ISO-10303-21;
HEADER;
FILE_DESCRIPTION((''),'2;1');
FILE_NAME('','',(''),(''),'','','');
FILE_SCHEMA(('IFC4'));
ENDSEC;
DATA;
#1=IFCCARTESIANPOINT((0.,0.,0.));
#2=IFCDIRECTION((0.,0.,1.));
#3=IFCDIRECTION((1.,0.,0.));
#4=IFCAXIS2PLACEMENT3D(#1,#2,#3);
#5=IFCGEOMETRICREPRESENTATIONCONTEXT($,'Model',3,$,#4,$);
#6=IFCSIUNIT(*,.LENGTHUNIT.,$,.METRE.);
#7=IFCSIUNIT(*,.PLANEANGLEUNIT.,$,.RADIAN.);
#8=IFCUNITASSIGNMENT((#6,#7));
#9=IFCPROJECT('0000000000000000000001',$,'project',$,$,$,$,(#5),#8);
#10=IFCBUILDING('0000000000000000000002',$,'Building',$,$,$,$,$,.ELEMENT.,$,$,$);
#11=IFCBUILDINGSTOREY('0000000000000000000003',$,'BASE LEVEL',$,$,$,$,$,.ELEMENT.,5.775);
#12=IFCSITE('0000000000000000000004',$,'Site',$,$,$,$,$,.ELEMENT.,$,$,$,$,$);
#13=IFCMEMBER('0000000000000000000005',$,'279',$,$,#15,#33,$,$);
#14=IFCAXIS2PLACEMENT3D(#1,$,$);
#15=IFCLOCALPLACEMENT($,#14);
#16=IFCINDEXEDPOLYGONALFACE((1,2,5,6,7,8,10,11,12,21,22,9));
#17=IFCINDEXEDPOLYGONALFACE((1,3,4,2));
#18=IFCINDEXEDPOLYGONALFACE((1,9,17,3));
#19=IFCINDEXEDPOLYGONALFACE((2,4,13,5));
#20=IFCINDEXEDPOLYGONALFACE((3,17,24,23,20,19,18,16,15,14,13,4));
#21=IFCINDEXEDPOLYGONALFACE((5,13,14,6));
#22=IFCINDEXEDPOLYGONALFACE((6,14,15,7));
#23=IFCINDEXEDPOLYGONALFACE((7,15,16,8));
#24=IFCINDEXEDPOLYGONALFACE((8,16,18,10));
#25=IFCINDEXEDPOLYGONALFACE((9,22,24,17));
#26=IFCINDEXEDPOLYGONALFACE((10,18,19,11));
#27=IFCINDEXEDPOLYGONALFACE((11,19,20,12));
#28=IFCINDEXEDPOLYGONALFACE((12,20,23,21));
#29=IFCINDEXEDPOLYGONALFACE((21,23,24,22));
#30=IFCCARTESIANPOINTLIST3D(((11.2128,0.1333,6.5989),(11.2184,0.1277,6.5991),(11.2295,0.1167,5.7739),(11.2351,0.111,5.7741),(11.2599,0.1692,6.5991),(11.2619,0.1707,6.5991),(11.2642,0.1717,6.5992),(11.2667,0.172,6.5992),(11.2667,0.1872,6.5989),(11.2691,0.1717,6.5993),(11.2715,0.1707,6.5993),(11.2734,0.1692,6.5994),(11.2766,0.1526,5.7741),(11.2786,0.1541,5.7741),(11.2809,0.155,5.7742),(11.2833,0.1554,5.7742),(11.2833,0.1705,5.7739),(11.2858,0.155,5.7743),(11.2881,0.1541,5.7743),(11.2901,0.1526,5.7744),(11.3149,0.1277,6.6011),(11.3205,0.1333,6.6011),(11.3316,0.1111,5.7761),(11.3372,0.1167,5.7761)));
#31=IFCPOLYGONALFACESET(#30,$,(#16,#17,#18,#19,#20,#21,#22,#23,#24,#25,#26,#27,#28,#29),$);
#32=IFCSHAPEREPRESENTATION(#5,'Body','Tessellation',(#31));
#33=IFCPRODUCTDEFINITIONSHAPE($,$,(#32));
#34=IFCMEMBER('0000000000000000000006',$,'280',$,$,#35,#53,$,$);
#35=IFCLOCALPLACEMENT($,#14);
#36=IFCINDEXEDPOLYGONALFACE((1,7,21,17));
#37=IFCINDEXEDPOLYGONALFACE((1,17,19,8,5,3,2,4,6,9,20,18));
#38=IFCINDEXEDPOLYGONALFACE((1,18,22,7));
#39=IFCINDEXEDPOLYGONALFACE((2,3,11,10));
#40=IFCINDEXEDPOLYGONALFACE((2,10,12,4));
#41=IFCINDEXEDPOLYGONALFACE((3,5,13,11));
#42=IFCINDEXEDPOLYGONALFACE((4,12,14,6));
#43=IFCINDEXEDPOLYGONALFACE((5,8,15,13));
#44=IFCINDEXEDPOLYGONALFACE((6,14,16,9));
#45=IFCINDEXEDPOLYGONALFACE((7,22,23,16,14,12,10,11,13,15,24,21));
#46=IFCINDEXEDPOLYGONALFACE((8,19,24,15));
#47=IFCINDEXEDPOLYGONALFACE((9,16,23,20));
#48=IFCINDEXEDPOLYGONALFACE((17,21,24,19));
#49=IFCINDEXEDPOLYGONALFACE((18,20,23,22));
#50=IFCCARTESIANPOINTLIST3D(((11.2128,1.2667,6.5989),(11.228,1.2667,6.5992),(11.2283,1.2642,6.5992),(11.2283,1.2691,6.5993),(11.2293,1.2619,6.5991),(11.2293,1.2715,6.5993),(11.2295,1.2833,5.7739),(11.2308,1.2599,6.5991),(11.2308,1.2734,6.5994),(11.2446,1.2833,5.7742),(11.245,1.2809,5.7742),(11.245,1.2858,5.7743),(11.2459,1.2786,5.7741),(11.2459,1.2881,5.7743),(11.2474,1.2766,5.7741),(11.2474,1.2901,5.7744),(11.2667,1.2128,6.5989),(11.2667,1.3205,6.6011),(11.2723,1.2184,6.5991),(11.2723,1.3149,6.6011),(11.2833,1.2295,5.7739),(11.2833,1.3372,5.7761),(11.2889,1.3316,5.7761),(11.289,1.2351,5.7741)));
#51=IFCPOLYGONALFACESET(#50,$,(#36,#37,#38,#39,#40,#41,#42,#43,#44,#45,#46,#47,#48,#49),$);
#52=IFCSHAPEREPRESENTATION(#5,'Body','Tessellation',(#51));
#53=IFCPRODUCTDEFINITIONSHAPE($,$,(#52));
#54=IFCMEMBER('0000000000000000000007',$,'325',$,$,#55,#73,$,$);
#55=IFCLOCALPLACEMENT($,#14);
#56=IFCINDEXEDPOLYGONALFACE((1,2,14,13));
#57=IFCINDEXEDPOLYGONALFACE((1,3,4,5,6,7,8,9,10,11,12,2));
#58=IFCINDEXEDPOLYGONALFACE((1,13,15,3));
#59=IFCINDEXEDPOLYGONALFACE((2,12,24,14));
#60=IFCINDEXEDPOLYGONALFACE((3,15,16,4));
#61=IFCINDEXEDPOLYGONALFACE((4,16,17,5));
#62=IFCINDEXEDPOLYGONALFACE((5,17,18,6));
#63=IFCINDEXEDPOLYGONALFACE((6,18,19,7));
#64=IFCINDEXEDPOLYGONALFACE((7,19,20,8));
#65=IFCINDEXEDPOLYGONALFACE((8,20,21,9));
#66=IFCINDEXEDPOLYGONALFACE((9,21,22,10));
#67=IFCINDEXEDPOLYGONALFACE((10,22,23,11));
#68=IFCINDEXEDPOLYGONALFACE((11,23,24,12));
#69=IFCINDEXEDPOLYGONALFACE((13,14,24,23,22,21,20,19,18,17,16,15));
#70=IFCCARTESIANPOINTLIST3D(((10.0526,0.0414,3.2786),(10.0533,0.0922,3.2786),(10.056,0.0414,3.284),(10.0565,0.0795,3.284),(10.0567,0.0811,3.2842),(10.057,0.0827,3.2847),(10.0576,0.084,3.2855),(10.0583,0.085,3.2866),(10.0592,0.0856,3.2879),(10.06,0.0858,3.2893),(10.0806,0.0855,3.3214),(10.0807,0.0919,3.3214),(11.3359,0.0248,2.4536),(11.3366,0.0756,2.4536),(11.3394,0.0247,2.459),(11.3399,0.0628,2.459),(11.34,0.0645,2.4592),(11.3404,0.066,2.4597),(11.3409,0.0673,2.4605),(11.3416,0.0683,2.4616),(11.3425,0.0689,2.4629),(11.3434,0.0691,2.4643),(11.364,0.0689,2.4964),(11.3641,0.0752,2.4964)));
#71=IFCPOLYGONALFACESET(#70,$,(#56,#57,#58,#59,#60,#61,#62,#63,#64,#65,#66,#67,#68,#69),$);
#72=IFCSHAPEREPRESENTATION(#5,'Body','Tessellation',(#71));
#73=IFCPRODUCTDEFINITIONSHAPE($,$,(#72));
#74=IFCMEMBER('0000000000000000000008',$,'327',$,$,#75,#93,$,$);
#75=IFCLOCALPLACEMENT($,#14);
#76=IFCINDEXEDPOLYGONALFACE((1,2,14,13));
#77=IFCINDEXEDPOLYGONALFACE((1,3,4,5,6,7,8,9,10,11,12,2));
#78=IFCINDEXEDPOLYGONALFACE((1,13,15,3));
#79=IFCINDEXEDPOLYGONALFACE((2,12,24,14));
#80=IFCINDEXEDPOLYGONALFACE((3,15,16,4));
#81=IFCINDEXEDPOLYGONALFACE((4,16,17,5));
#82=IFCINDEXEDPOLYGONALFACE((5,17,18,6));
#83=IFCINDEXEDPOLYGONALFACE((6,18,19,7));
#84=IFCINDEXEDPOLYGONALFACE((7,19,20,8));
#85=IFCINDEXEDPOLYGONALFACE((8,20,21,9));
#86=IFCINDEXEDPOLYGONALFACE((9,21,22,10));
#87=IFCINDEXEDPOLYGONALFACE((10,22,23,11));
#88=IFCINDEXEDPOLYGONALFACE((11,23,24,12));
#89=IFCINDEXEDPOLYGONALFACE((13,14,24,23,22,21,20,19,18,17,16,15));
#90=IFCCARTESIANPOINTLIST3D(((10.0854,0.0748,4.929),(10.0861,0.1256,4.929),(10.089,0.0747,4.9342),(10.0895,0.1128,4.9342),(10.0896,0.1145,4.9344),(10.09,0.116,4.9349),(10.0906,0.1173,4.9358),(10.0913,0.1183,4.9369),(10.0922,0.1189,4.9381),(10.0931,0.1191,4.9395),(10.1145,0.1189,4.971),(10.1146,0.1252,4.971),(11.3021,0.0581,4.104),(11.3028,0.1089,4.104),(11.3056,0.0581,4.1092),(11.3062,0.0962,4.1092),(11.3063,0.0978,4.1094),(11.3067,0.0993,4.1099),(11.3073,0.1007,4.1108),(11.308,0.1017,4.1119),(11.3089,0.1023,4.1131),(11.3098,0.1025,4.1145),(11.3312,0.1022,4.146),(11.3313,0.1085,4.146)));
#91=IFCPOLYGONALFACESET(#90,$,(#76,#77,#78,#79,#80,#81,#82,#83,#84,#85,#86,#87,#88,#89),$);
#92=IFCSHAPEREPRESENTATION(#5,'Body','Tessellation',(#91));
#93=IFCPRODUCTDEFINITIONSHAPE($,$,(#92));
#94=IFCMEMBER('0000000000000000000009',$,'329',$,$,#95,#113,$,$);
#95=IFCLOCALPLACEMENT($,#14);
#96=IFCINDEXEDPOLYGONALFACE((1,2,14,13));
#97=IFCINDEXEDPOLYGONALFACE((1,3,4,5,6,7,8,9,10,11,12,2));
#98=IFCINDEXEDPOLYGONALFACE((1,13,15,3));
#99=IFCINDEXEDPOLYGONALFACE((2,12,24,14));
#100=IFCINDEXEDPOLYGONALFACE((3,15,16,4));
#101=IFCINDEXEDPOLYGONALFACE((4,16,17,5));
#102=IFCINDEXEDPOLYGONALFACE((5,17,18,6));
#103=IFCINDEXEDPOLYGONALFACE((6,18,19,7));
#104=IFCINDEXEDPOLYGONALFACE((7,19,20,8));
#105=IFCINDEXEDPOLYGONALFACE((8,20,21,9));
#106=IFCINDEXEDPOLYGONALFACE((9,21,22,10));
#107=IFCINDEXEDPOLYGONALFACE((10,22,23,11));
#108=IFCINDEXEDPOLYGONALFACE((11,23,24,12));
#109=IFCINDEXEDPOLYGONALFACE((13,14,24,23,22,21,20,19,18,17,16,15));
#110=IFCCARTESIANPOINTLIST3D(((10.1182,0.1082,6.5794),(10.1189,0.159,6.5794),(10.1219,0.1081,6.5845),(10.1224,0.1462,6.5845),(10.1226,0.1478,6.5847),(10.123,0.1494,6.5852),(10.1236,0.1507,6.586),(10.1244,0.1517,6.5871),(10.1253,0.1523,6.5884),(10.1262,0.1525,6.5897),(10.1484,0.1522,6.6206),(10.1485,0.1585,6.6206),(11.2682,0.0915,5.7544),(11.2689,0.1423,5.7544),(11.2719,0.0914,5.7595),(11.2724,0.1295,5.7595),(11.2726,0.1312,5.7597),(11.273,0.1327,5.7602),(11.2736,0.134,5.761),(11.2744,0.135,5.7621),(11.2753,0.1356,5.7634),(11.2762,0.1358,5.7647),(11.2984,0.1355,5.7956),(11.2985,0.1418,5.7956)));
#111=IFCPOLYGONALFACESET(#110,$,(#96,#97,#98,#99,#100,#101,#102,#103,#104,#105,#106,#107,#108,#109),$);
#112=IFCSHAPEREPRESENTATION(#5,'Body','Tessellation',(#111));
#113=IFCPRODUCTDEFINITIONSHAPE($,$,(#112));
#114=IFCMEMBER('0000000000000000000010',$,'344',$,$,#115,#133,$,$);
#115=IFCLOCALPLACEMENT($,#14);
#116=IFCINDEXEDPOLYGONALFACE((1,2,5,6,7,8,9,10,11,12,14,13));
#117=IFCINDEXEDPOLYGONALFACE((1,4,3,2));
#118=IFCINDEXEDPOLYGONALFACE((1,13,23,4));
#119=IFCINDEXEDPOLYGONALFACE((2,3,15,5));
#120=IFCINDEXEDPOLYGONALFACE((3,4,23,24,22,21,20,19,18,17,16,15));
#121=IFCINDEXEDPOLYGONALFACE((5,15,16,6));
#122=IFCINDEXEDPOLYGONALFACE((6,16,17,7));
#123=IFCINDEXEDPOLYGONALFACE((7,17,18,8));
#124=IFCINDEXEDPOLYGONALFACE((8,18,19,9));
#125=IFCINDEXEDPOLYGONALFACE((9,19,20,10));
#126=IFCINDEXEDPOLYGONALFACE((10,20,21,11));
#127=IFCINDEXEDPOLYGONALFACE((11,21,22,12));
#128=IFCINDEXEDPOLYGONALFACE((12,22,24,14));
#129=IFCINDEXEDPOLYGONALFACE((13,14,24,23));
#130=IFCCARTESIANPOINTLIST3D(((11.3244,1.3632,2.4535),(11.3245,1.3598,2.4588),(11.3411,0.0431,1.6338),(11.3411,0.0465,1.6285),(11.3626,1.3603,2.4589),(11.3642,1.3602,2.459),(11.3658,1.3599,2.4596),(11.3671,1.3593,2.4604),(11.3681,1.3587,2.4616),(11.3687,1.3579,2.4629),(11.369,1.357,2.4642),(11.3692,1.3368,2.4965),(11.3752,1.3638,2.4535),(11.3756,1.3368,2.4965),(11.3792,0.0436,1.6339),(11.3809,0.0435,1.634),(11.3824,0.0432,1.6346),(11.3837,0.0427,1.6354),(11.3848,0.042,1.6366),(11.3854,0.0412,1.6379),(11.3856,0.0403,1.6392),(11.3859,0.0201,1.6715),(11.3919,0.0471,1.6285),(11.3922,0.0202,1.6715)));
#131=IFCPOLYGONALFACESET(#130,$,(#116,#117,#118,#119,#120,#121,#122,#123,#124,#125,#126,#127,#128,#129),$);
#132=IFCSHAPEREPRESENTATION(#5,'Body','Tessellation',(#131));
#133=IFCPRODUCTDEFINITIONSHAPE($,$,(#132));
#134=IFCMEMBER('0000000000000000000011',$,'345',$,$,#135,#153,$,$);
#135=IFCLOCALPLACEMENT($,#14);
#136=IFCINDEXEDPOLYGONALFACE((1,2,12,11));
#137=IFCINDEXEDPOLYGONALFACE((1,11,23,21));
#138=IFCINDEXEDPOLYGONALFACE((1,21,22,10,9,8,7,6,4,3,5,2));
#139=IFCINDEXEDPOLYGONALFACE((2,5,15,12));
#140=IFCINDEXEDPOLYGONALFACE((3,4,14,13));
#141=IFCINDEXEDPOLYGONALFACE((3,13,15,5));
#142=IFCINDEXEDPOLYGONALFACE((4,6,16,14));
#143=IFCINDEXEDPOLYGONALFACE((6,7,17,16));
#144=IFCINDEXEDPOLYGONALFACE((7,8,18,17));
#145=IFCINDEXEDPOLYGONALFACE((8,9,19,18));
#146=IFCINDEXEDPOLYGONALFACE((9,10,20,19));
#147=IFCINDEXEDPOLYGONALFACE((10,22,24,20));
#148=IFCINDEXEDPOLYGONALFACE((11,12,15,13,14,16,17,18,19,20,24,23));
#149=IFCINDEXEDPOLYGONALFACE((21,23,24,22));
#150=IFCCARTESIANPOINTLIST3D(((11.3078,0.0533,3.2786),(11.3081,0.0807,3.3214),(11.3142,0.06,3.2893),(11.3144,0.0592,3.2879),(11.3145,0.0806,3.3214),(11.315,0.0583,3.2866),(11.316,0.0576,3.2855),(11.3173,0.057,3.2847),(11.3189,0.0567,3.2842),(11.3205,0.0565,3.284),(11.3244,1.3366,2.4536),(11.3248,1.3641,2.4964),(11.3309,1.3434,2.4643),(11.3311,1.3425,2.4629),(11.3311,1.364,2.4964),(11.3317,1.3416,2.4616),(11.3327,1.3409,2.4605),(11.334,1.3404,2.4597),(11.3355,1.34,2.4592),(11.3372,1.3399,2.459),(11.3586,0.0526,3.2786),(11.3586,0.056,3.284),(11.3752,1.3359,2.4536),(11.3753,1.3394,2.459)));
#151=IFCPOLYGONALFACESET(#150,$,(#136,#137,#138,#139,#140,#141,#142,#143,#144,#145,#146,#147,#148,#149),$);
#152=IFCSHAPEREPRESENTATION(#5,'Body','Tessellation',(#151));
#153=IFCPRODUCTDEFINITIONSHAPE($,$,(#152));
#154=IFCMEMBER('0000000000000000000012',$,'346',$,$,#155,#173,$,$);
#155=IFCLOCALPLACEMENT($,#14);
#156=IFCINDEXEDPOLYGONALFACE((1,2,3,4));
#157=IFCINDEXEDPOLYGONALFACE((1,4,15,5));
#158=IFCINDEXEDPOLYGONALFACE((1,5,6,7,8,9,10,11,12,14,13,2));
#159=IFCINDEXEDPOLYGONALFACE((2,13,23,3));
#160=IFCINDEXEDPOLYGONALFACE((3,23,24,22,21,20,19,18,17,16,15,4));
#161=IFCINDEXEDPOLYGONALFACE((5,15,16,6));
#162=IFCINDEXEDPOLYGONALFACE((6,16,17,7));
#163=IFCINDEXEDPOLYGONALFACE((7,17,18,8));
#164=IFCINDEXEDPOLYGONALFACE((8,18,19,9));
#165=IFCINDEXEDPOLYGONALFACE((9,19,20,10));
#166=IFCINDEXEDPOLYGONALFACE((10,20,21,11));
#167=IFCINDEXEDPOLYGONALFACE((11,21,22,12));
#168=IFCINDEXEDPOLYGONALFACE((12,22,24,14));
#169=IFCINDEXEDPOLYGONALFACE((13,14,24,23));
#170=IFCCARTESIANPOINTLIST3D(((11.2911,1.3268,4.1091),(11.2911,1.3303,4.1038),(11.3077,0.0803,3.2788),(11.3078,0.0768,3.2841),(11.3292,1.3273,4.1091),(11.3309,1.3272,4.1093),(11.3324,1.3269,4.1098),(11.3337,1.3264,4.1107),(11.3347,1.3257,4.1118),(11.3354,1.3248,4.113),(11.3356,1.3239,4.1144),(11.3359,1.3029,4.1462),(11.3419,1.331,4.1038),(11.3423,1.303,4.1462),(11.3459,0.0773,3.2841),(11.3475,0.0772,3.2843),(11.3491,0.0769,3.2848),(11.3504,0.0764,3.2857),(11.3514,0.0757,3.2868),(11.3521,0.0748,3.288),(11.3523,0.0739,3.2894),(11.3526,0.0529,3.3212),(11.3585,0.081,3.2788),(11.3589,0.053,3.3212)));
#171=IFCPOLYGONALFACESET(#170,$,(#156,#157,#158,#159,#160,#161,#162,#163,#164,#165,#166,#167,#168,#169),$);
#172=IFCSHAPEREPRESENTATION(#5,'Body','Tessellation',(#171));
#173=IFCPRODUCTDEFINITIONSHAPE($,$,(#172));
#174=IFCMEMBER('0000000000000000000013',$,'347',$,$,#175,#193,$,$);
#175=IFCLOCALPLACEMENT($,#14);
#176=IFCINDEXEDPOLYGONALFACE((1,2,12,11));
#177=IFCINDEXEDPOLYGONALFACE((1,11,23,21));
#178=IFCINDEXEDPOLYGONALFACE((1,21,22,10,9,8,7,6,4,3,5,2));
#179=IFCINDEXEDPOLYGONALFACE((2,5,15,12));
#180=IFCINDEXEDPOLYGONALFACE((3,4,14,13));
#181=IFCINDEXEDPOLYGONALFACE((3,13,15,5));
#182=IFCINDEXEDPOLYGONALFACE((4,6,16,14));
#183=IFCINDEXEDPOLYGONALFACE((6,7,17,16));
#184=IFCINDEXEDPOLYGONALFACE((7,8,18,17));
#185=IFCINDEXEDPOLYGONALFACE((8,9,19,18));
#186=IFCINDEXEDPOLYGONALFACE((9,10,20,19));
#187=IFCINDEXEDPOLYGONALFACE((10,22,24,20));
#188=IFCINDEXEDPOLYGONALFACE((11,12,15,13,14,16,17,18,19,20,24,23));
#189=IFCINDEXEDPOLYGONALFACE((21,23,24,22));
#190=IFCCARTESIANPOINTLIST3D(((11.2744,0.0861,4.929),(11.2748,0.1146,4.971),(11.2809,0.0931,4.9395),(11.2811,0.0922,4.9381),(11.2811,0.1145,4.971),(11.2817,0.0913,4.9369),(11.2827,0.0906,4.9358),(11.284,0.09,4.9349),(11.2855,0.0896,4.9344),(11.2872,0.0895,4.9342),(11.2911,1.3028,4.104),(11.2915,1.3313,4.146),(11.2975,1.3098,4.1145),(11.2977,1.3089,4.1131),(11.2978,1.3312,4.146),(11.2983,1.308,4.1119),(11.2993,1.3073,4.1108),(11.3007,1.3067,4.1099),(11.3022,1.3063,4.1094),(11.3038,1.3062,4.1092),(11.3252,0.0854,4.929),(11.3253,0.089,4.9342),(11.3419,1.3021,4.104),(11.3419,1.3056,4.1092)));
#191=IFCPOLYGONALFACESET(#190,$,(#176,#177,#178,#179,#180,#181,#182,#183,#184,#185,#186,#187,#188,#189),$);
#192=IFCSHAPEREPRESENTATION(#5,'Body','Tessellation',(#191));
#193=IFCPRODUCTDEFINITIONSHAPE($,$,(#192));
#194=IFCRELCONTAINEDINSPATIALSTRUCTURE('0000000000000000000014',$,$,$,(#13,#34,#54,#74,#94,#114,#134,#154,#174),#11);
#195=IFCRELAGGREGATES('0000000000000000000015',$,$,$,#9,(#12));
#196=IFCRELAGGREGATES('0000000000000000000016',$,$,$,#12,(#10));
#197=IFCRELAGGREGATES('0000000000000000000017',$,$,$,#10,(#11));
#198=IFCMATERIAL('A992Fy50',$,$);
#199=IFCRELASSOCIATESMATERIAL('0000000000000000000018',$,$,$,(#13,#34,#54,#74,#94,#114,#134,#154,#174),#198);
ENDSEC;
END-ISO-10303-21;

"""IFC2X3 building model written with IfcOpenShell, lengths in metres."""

from ifc_helpers import new_model, si_unit, frame, origin_with_axes, origin_2d_with_axis, place, context, project, spatial, l_section, extrude, material, element, save


model = new_model("IFC2X3")

# Units and contexts
model_context = context("Model", 3, world=origin_with_axes())
ifc_project = project(units=[si_unit("LENGTHUNIT", "METRE"), si_unit("PLANEANGLEUNIT", "RADIAN")], contexts=[model_context])

# Site, building, storey
site = spatial("IfcSite", under=ifc_project, Name="Site", CompositionType="ELEMENT")
building = spatial("IfcBuilding", under=site, Name="Building", CompositionType="ELEMENT")
storey = spatial("IfcBuildingStorey", under=building, Name="BASE LEVEL", CompositionType="ELEMENT", Elevation=5.775)

# Members
ifc_material = material(Name="A992Fy50")
for number, where, z_axis, x_axis, name in (
    (1, (11.2833, 0.1167, 5.775), (-0.020194, 0.020194, 0.999592), (-0.707107, -0.707107, 0.0), "279"),
    (2, (11.2833, 1.2833, 5.775), (-0.020194, -0.020194, 0.999592), (0.707107, -0.707107, 0.0), "280"),
):
    element("IfcMember", number, at=place(None, frame(where, z_axis=z_axis, x_axis=x_axis)), inside=storey, material=ifc_material, Name=name, context=model_context, shape_type="SweptSolid", body=[
        extrude(l_section(Depth=0.0762, Width=0.0762, Thickness=0.0079, FilletRadius=0.0096, at=origin_2d_with_axis()), origin_with_axes(), (0.0, 0.0, 1.0), 0.8253),
    ])
member_1_placement = place(None, frame((11.35, 0.05, 2.475), z_axis=(-0.841128, 0.010924, 0.540725), x_axis=(-0.012345, -0.999924, 0.0)))
element("IfcMember", 3, at=member_1_placement, inside=storey, material=ifc_material, Name="325", context=model_context, shape_type="SweptSolid", body=[
    extrude(l_section(Depth=0.0508, Width=0.0508, Thickness=0.0063, FilletRadius=0.0063, at=origin_2d_with_axis()), origin_with_axes(), (0.0, 0.0, 1.0), 1.5257),
])
member_2_placement = place(None, frame((11.3167, 0.0833, 4.125), z_axis=(-0.827611, 0.011337, 0.561188), x_axis=(-0.013697, -0.999906, 0.0)))
element("IfcMember", 4, at=member_2_placement, inside=storey, material=ifc_material, Name="327", context=model_context, shape_type="SweptSolid", body=[
    extrude(l_section(Depth=0.0508, Width=0.0508, Thickness=0.0063, FilletRadius=0.0063, at=origin_2d_with_axis()), origin_with_axes(), (0.0, 0.0, 1.0), 1.4701),
])
member_3_placement = place(None, frame((11.2833, 0.1167, 5.775), z_axis=(-0.812482, 0.011775, 0.582867), x_axis=(-0.015383, -0.999882, 0.0)))
element("IfcMember", 5, at=member_3_placement, inside=storey, material=ifc_material, Name="329", context=model_context, shape_type="SweptSolid", body=[
    extrude(l_section(Depth=0.0508, Width=0.0508, Thickness=0.0063, FilletRadius=0.0063, at=origin_2d_with_axis()), origin_with_axes(), (0.0, 0.0, 1.0), 1.4154),
])
member_4_placement = place(None, frame((11.3667, 0.0333, 1.65), z_axis=(-0.010726, 0.847346, 0.530932), x_axis=(-0.999927, -0.012047, 0.0)))
element("IfcMember", 6, at=member_4_placement, inside=storey, material=ifc_material, Name="344", context=model_context, shape_type="SweptSolid", body=[
    extrude(l_section(Depth=0.0508, Width=0.0508, Thickness=0.0063, FilletRadius=0.0063, at=origin_2d_with_axis()), origin_with_axes(), (0.0, 0.0, 1.0), 1.5539),
])
member_5_placement = place(None, frame((11.35, 1.35, 2.475), z_axis=(-0.010924, -0.841128, 0.540725), x_axis=(0.999924, -0.012345, 0.0)))
element("IfcMember", 7, at=member_5_placement, inside=storey, material=ifc_material, Name="345", context=model_context, shape_type="SweptSolid", body=[
    extrude(l_section(Depth=0.0508, Width=0.0508, Thickness=0.0063, FilletRadius=0.0063, at=origin_2d_with_axis()), origin_with_axes(), (0.0, 0.0, 1.0), 1.5257),
])
member_6_placement = place(None, frame((11.3333, 0.0667, 3.3), z_axis=(-0.011127, 0.834558, 0.550808), x_axis=(-0.999911, -0.013332, 0.0)))
element("IfcMember", 8, at=member_6_placement, inside=storey, material=ifc_material, Name="346", context=model_context, shape_type="SweptSolid", body=[
    extrude(l_section(Depth=0.0508, Width=0.0508, Thickness=0.0063, FilletRadius=0.0063, at=origin_2d_with_axis()), origin_with_axes(), (0.0, 0.0, 1.0), 1.4978),
])
member_7_placement = place(None, frame((11.3167, 1.3167, 4.125), z_axis=(-0.011337, -0.827611, 0.561188), x_axis=(0.999906, -0.013697, 0.0)))
element("IfcMember", 9, at=member_7_placement, inside=storey, material=ifc_material, Name="347", context=model_context, shape_type="SweptSolid", body=[
    extrude(l_section(Depth=0.0508, Width=0.0508, Thickness=0.0063, FilletRadius=0.0063, at=origin_2d_with_axis()), origin_with_axes(), (0.0, 0.0, 1.0), 1.4701),
])

save(model, "model.ifc")
